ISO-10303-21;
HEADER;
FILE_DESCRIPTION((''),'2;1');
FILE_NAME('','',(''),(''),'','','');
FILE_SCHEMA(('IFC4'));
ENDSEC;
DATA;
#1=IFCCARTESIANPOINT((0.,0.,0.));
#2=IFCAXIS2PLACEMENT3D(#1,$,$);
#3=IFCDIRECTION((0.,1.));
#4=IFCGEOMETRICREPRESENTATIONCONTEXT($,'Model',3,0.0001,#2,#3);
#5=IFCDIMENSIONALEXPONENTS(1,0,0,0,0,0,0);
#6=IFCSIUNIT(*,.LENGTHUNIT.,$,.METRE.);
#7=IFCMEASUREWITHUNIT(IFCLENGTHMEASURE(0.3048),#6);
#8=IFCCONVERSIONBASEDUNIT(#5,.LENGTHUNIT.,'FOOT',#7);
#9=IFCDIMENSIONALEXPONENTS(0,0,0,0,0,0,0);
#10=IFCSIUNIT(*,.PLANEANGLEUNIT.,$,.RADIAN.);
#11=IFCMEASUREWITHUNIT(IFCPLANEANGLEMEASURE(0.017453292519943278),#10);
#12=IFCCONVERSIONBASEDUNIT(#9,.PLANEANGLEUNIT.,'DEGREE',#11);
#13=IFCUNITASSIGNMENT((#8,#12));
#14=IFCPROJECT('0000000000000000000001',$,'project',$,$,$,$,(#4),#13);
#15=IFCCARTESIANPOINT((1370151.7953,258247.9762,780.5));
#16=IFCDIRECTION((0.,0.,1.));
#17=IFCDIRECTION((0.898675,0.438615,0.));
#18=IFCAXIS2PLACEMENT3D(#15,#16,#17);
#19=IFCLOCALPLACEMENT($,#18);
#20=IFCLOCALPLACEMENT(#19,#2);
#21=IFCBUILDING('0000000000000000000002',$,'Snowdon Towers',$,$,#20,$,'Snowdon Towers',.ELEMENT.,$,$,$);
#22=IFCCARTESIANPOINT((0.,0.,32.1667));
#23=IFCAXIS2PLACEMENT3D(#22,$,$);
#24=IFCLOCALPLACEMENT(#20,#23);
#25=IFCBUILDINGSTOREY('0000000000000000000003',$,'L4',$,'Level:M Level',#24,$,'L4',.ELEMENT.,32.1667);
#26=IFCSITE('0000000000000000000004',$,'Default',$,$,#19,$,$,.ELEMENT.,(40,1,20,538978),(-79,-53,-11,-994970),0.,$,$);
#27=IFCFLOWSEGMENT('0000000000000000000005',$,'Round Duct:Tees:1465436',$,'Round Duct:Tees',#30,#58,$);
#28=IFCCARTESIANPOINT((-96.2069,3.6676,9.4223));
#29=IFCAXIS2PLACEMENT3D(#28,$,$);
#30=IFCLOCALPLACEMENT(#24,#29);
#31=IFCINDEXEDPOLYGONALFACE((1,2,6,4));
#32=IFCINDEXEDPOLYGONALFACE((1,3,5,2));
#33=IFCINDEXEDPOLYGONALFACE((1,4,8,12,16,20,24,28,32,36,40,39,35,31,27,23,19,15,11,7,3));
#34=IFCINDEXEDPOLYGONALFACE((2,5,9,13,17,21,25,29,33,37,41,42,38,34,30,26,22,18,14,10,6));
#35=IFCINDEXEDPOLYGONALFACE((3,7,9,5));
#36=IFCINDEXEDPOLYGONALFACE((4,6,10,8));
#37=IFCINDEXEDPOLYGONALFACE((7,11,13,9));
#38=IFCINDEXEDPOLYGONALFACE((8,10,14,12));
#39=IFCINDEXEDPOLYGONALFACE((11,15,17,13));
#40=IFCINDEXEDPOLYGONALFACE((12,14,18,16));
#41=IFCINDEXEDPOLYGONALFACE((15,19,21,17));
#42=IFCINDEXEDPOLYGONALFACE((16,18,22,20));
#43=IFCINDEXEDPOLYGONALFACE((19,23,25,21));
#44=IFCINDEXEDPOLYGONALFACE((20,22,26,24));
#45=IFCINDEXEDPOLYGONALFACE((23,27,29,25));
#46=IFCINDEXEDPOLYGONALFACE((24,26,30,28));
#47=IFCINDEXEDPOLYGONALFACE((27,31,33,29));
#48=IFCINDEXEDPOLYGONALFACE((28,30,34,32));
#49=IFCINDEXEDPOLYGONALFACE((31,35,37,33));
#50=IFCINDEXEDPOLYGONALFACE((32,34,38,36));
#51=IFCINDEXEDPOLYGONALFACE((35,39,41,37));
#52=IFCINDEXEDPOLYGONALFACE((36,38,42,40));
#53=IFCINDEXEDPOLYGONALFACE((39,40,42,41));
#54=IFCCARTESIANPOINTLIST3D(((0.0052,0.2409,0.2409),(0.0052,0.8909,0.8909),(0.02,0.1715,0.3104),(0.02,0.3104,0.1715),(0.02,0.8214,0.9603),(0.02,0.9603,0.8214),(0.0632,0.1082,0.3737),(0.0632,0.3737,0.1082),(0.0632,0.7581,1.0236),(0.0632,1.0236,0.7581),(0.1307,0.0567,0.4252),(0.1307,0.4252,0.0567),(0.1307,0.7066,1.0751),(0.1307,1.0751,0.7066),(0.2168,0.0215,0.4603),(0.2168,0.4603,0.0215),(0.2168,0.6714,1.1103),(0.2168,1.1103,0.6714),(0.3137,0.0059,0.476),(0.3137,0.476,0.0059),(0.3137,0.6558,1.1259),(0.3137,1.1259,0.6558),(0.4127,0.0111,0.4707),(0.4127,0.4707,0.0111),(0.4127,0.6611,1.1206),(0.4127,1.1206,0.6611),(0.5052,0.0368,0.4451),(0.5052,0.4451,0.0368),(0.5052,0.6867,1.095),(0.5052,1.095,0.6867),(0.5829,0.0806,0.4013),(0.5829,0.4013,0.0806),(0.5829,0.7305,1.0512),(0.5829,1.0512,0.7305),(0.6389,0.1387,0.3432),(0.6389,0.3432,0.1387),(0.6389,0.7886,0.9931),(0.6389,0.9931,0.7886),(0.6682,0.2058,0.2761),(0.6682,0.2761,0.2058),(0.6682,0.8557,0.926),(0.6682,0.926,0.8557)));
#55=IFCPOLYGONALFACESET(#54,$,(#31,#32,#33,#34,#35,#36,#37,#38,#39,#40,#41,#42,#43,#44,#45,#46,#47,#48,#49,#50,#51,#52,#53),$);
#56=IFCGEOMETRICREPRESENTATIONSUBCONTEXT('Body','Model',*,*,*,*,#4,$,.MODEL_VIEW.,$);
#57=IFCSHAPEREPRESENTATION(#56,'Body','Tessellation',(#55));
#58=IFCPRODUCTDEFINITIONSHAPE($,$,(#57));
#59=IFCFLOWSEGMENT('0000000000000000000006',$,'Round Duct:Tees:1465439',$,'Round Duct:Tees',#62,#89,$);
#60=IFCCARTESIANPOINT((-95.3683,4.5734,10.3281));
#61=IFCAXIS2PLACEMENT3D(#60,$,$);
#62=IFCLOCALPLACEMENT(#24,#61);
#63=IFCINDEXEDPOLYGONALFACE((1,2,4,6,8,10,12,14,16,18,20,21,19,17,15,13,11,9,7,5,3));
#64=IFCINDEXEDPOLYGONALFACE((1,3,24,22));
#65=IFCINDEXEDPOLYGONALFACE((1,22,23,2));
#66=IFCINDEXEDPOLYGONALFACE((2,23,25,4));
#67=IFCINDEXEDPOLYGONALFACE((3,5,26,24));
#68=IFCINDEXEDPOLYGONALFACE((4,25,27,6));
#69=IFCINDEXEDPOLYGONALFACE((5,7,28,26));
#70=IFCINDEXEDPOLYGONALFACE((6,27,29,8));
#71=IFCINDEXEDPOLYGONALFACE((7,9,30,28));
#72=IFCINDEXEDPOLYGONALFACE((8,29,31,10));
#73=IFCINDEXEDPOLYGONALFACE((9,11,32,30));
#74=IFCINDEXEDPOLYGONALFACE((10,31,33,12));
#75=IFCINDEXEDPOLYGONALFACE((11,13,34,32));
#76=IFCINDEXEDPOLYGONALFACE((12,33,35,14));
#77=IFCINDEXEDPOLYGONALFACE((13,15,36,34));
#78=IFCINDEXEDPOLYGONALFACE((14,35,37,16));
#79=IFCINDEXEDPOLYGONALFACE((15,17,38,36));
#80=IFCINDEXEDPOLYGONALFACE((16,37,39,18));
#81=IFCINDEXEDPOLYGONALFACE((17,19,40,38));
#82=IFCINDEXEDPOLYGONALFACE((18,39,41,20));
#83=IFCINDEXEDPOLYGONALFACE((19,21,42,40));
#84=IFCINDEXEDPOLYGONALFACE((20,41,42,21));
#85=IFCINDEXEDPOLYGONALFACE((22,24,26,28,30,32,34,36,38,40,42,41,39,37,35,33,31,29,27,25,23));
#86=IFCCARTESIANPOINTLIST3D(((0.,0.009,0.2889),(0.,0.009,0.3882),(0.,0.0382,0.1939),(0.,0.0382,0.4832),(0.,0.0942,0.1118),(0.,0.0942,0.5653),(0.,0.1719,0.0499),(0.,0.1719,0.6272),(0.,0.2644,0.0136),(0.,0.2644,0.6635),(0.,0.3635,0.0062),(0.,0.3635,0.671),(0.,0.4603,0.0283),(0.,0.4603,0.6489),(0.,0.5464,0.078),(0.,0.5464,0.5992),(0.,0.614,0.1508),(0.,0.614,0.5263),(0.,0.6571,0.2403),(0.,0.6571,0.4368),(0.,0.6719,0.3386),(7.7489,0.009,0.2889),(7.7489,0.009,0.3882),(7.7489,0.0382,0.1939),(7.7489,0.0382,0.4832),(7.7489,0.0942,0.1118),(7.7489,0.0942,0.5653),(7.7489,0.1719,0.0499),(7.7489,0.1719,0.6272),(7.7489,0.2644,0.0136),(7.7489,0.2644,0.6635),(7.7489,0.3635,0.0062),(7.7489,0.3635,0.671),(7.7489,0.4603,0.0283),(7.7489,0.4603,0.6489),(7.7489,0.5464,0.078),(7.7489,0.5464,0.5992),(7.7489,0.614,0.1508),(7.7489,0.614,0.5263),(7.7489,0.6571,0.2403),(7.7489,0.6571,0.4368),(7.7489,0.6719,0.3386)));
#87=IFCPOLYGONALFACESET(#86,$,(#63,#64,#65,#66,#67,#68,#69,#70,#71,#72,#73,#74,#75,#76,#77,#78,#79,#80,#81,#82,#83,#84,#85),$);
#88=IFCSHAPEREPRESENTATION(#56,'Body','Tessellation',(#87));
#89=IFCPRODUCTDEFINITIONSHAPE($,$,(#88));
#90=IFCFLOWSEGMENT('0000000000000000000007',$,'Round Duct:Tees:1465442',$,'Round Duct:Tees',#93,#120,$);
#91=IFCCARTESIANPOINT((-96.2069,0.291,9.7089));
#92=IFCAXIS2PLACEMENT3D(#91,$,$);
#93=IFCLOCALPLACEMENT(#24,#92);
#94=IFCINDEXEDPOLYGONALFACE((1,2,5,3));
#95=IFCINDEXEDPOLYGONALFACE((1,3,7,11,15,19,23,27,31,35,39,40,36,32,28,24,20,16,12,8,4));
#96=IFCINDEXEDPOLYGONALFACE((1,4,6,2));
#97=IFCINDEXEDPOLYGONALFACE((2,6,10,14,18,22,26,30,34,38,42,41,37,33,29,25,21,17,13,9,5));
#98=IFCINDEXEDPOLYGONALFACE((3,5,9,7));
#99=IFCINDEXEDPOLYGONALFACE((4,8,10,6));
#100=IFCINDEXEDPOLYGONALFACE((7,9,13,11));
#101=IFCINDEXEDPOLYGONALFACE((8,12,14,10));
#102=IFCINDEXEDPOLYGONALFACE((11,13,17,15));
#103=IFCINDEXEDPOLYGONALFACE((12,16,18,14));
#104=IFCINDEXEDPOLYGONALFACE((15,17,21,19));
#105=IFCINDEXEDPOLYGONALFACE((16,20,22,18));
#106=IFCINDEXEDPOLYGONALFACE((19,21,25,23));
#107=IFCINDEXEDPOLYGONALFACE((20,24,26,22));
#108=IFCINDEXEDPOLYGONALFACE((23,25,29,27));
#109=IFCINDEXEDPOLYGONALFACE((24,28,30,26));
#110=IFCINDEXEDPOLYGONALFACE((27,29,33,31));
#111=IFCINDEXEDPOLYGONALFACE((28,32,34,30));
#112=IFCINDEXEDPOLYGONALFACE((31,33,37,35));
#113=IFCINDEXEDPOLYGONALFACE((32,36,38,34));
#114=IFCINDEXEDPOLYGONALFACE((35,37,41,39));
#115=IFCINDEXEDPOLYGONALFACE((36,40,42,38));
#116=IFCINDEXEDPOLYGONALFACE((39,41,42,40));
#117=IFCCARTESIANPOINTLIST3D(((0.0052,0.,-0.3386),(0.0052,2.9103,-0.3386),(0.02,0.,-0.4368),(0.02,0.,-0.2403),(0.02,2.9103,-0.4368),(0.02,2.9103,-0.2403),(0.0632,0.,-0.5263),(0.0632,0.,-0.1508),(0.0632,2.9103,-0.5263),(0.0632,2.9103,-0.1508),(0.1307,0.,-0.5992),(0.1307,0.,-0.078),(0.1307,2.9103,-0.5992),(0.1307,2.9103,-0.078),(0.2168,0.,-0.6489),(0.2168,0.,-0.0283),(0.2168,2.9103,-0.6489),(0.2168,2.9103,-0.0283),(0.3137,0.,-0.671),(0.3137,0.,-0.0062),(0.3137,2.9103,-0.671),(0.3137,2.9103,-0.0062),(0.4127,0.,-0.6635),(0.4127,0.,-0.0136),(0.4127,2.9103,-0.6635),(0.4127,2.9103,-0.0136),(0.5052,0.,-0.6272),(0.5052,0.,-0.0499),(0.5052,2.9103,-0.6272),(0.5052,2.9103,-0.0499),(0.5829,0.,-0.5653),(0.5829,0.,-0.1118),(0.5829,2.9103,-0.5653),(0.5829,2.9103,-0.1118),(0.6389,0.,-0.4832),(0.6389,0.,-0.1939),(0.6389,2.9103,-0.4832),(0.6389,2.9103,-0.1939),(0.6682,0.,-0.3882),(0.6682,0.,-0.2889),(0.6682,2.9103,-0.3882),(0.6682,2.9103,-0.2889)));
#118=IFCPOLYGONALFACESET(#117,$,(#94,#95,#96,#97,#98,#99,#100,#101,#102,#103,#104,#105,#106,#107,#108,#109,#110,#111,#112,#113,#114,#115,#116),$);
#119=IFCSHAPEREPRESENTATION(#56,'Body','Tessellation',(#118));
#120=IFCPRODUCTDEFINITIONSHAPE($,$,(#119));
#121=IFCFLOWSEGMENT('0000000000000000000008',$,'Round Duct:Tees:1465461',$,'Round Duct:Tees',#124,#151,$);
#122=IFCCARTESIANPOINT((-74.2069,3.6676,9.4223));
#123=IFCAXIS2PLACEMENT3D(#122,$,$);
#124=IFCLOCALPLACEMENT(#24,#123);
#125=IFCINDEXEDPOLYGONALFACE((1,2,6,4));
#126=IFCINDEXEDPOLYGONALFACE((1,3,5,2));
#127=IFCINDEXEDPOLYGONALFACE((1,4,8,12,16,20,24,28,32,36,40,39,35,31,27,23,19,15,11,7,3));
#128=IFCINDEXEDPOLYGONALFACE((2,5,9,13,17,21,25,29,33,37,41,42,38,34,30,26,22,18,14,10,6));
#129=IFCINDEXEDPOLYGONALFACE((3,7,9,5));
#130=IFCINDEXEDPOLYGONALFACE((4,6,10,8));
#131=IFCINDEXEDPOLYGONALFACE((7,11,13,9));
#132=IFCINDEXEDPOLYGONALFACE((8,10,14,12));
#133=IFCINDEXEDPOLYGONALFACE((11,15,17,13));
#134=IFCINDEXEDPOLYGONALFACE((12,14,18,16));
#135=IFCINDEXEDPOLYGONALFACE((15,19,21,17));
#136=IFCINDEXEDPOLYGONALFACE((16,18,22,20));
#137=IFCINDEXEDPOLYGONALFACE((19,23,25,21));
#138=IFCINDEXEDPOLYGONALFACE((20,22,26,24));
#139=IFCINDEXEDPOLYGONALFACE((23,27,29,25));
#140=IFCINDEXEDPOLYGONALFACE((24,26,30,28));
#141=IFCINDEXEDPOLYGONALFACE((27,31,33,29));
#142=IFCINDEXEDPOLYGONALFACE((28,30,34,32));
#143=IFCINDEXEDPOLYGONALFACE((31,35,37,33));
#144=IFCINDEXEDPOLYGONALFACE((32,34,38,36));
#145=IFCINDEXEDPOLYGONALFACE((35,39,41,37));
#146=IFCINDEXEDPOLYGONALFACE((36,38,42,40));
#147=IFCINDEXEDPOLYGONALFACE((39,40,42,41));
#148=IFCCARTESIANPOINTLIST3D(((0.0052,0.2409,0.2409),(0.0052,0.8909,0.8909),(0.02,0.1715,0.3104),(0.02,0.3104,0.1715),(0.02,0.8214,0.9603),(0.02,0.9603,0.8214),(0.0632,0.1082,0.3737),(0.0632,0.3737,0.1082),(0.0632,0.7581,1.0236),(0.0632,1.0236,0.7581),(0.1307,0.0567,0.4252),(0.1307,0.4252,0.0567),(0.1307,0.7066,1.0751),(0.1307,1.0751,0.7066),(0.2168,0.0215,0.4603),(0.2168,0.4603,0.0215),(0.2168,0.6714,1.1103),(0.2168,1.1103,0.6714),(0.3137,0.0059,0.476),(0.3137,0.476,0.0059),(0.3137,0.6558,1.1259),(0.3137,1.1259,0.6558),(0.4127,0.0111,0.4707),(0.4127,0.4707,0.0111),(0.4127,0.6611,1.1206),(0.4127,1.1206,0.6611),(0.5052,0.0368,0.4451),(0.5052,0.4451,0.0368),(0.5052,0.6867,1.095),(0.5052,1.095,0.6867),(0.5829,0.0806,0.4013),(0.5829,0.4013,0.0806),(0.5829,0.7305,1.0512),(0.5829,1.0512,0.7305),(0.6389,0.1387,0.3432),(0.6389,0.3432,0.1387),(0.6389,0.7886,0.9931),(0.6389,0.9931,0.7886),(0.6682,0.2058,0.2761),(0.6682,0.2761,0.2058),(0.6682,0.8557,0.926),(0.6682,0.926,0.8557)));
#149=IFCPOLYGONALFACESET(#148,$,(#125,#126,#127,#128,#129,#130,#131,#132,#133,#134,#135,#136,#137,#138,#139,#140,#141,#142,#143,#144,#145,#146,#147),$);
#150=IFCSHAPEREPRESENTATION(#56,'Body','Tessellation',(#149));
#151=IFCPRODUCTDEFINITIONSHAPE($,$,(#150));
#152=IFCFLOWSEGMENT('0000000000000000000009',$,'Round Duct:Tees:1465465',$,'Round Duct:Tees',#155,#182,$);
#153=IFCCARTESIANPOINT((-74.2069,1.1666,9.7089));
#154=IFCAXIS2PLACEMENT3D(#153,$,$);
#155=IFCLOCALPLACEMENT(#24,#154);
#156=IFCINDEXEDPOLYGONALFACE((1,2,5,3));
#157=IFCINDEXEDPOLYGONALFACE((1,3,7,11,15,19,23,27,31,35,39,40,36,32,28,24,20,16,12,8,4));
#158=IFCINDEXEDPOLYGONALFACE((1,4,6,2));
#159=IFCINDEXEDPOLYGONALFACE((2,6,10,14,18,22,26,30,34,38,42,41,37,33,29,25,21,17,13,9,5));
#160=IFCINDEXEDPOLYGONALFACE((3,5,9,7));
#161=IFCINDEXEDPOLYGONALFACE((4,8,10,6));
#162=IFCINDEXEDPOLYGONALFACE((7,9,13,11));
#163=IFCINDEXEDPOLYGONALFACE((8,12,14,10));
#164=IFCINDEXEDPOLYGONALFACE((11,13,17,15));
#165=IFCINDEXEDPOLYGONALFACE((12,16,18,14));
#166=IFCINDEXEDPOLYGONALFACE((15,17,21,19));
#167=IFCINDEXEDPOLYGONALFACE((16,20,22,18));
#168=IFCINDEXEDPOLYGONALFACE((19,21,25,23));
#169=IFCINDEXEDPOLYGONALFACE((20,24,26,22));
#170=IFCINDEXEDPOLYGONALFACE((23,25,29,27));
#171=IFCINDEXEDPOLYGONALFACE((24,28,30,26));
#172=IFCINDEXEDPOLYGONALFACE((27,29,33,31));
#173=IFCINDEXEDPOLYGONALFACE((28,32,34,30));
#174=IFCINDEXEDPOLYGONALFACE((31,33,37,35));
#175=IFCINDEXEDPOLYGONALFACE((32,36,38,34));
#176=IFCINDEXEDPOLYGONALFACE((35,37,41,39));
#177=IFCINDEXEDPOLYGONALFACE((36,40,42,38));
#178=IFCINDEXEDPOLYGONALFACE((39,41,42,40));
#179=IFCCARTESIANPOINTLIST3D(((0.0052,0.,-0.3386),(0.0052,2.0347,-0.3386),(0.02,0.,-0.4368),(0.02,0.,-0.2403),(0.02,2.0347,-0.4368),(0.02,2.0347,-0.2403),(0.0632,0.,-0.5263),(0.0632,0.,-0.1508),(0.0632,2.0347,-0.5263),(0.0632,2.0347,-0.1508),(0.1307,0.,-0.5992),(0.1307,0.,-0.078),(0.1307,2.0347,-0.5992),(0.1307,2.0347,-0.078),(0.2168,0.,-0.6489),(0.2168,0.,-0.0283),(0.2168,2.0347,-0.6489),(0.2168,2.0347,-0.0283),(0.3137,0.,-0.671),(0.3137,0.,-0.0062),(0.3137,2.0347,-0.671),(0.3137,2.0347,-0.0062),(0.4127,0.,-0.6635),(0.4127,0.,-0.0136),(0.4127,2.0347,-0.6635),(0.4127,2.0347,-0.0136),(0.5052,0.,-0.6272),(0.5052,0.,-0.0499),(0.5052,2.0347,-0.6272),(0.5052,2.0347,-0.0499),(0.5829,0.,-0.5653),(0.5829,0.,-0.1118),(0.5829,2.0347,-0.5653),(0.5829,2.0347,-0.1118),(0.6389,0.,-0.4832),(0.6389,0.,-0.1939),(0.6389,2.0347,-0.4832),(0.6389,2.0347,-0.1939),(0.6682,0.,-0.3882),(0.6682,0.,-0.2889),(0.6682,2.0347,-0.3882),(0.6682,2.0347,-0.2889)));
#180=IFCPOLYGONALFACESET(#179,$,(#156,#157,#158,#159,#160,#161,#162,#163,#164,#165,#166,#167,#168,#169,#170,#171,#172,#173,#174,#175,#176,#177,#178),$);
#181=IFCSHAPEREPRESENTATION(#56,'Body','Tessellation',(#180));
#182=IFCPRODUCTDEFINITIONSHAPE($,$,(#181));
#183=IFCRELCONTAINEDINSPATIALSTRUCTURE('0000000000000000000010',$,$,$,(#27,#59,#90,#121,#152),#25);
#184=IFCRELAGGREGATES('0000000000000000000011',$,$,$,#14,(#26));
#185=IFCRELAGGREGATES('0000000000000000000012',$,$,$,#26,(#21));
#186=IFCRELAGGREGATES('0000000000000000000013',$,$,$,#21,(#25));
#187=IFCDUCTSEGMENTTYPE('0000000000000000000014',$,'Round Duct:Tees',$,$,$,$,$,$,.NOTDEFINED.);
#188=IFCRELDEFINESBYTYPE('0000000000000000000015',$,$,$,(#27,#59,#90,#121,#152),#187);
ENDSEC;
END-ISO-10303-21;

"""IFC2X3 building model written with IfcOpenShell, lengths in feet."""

from ifc_helpers import new_model, entity, si_unit, converted_unit, direction, frame, frame_2d, origin, place, context, subcontext, project, spatial, circle, extrude, type_object, element, save


model = new_model("IFC2X3")

# Units and contexts
model_context = context("Model", 3, precision=0.0001, world=origin(), true_north=direction((0.0, 1.0)))
body_context = subcontext(model_context, "Body", "Model", "MODEL_VIEW")
ifc_project = project(units=[converted_unit("LENGTHUNIT", "FOOT", entity("IfcLengthMeasure", 0.3048), si_unit("LENGTHUNIT", "METRE"), dimensions=[1, 0, 0, 0, 0, 0, 0]), converted_unit("PLANEANGLEUNIT", "DEGREE", entity("IfcPlaneAngleMeasure", 0.017453292519943278), si_unit("PLANEANGLEUNIT", "RADIAN"), dimensions=[0, 0, 0, 0, 0, 0, 0])], contexts=[model_context])

# Site, building, storey
site_placement = place(None, frame((1370151.7953, 258247.9762, 780.5), z_axis=(0.0, 0.0, 1.0), x_axis=(0.898675, 0.438615, 0.0)))
site = spatial("IfcSite", under=ifc_project, at=site_placement, Name="Default", CompositionType="ELEMENT", RefLatitude=(40, 1, 20, 538978), RefLongitude=(-79, -53, -11, -994970), RefElevation=0.0)
building_placement = place(site_placement, origin())
building = spatial("IfcBuilding", under=site, at=building_placement, Name="Snowdon Towers", LongName="Snowdon Towers", CompositionType="ELEMENT")
storey_placement = place(building_placement, frame((0.0, 0.0, 32.1667)))
storey = spatial("IfcBuildingStorey", under=building, at=storey_placement, Name="L4", ObjectType="Level:M Level", LongName="L4", CompositionType="ELEMENT", Elevation=32.1667)

# Flow segments
duct_segment_type = type_object("IfcDuctSegmentType", Name="Round Duct:Tees", PredefinedType="NOTDEFINED")
flow_segment_1_placement = place(storey_placement, frame((-96.2069, 3.6676, 9.4223)))
element("IfcFlowSegment", 1, at=flow_segment_1_placement, inside=storey, type_object=duct_segment_type, Name="Round Duct:Tees:1465436", ObjectType="Round Duct:Tees", context=body_context, shape_type="SweptSolid", body=[
    extrude(circle(Radius=0.3333, at=frame_2d((0.0, 0.0), x_axis=(1.0, 0.0))), frame((0.3386, 0.2409, 0.2409), z_axis=(0.0, 0.707107, 0.707107), x_axis=(-1.0, 0.0, 0.0)), (0.0, 0.0, 1.0), 0.9191),
])
flow_segment_2_placement = place(storey_placement, frame((-95.3683, 4.5734, 10.3281)))
element("IfcFlowSegment", 2, at=flow_segment_2_placement, inside=storey, type_object=duct_segment_type, Name="Round Duct:Tees:1465439", ObjectType="Round Duct:Tees", context=body_context, shape_type="SweptSolid", body=[
    extrude(circle(Radius=0.3333, at=frame_2d((0.0, 0.0), x_axis=(1.0, 0.0))), frame((0.0, 0.3386, 0.3386), z_axis=(1.0, 0.0, 0.0), x_axis=(0.0, 1.0, 0.0)), (0.0, 0.0, 1.0), 7.7489),
])
flow_segment_3_placement = place(storey_placement, frame((-96.2069, 0.291, 9.7089)))
element("IfcFlowSegment", 3, at=flow_segment_3_placement, inside=storey, type_object=duct_segment_type, Name="Round Duct:Tees:1465442", ObjectType="Round Duct:Tees", context=body_context, shape_type="SweptSolid", body=[
    extrude(circle(Radius=0.3333, at=frame_2d((0.0, 0.0), x_axis=(1.0, 0.0))), frame((0.3386, 0.0, -0.3386), z_axis=(0.0, 1.0, 0.0), x_axis=(-1.0, 0.0, 0.0)), (0.0, 0.0, 1.0), 2.9103),
])
flow_segment_4_placement = place(storey_placement, frame((-74.2069, 3.6676, 9.4223)))
element("IfcFlowSegment", 4, at=flow_segment_4_placement, inside=storey, type_object=duct_segment_type, Name="Round Duct:Tees:1465461", ObjectType="Round Duct:Tees", context=body_context, shape_type="SweptSolid", body=[
    extrude(circle(Radius=0.3333, at=frame_2d((0.0, 0.0), x_axis=(1.0, 0.0))), frame((0.3386, 0.2409, 0.2409), z_axis=(0.0, 0.707107, 0.707107), x_axis=(-1.0, 0.0, 0.0)), (0.0, 0.0, 1.0), 0.9191),
])
flow_segment_5_placement = place(storey_placement, frame((-74.2069, 1.1666, 9.7089)))
element("IfcFlowSegment", 5, at=flow_segment_5_placement, inside=storey, type_object=duct_segment_type, Name="Round Duct:Tees:1465465", ObjectType="Round Duct:Tees", context=body_context, shape_type="SweptSolid", body=[
    extrude(circle(Radius=0.3333, at=frame_2d((0.0, 0.0), x_axis=(1.0, 0.0))), frame((0.3386, 0.0, -0.3386), z_axis=(0.0, 1.0, 0.0), x_axis=(-1.0, 0.0, 0.0)), (0.0, 0.0, 1.0), 2.0347),
])

save(model, "model.ifc")
